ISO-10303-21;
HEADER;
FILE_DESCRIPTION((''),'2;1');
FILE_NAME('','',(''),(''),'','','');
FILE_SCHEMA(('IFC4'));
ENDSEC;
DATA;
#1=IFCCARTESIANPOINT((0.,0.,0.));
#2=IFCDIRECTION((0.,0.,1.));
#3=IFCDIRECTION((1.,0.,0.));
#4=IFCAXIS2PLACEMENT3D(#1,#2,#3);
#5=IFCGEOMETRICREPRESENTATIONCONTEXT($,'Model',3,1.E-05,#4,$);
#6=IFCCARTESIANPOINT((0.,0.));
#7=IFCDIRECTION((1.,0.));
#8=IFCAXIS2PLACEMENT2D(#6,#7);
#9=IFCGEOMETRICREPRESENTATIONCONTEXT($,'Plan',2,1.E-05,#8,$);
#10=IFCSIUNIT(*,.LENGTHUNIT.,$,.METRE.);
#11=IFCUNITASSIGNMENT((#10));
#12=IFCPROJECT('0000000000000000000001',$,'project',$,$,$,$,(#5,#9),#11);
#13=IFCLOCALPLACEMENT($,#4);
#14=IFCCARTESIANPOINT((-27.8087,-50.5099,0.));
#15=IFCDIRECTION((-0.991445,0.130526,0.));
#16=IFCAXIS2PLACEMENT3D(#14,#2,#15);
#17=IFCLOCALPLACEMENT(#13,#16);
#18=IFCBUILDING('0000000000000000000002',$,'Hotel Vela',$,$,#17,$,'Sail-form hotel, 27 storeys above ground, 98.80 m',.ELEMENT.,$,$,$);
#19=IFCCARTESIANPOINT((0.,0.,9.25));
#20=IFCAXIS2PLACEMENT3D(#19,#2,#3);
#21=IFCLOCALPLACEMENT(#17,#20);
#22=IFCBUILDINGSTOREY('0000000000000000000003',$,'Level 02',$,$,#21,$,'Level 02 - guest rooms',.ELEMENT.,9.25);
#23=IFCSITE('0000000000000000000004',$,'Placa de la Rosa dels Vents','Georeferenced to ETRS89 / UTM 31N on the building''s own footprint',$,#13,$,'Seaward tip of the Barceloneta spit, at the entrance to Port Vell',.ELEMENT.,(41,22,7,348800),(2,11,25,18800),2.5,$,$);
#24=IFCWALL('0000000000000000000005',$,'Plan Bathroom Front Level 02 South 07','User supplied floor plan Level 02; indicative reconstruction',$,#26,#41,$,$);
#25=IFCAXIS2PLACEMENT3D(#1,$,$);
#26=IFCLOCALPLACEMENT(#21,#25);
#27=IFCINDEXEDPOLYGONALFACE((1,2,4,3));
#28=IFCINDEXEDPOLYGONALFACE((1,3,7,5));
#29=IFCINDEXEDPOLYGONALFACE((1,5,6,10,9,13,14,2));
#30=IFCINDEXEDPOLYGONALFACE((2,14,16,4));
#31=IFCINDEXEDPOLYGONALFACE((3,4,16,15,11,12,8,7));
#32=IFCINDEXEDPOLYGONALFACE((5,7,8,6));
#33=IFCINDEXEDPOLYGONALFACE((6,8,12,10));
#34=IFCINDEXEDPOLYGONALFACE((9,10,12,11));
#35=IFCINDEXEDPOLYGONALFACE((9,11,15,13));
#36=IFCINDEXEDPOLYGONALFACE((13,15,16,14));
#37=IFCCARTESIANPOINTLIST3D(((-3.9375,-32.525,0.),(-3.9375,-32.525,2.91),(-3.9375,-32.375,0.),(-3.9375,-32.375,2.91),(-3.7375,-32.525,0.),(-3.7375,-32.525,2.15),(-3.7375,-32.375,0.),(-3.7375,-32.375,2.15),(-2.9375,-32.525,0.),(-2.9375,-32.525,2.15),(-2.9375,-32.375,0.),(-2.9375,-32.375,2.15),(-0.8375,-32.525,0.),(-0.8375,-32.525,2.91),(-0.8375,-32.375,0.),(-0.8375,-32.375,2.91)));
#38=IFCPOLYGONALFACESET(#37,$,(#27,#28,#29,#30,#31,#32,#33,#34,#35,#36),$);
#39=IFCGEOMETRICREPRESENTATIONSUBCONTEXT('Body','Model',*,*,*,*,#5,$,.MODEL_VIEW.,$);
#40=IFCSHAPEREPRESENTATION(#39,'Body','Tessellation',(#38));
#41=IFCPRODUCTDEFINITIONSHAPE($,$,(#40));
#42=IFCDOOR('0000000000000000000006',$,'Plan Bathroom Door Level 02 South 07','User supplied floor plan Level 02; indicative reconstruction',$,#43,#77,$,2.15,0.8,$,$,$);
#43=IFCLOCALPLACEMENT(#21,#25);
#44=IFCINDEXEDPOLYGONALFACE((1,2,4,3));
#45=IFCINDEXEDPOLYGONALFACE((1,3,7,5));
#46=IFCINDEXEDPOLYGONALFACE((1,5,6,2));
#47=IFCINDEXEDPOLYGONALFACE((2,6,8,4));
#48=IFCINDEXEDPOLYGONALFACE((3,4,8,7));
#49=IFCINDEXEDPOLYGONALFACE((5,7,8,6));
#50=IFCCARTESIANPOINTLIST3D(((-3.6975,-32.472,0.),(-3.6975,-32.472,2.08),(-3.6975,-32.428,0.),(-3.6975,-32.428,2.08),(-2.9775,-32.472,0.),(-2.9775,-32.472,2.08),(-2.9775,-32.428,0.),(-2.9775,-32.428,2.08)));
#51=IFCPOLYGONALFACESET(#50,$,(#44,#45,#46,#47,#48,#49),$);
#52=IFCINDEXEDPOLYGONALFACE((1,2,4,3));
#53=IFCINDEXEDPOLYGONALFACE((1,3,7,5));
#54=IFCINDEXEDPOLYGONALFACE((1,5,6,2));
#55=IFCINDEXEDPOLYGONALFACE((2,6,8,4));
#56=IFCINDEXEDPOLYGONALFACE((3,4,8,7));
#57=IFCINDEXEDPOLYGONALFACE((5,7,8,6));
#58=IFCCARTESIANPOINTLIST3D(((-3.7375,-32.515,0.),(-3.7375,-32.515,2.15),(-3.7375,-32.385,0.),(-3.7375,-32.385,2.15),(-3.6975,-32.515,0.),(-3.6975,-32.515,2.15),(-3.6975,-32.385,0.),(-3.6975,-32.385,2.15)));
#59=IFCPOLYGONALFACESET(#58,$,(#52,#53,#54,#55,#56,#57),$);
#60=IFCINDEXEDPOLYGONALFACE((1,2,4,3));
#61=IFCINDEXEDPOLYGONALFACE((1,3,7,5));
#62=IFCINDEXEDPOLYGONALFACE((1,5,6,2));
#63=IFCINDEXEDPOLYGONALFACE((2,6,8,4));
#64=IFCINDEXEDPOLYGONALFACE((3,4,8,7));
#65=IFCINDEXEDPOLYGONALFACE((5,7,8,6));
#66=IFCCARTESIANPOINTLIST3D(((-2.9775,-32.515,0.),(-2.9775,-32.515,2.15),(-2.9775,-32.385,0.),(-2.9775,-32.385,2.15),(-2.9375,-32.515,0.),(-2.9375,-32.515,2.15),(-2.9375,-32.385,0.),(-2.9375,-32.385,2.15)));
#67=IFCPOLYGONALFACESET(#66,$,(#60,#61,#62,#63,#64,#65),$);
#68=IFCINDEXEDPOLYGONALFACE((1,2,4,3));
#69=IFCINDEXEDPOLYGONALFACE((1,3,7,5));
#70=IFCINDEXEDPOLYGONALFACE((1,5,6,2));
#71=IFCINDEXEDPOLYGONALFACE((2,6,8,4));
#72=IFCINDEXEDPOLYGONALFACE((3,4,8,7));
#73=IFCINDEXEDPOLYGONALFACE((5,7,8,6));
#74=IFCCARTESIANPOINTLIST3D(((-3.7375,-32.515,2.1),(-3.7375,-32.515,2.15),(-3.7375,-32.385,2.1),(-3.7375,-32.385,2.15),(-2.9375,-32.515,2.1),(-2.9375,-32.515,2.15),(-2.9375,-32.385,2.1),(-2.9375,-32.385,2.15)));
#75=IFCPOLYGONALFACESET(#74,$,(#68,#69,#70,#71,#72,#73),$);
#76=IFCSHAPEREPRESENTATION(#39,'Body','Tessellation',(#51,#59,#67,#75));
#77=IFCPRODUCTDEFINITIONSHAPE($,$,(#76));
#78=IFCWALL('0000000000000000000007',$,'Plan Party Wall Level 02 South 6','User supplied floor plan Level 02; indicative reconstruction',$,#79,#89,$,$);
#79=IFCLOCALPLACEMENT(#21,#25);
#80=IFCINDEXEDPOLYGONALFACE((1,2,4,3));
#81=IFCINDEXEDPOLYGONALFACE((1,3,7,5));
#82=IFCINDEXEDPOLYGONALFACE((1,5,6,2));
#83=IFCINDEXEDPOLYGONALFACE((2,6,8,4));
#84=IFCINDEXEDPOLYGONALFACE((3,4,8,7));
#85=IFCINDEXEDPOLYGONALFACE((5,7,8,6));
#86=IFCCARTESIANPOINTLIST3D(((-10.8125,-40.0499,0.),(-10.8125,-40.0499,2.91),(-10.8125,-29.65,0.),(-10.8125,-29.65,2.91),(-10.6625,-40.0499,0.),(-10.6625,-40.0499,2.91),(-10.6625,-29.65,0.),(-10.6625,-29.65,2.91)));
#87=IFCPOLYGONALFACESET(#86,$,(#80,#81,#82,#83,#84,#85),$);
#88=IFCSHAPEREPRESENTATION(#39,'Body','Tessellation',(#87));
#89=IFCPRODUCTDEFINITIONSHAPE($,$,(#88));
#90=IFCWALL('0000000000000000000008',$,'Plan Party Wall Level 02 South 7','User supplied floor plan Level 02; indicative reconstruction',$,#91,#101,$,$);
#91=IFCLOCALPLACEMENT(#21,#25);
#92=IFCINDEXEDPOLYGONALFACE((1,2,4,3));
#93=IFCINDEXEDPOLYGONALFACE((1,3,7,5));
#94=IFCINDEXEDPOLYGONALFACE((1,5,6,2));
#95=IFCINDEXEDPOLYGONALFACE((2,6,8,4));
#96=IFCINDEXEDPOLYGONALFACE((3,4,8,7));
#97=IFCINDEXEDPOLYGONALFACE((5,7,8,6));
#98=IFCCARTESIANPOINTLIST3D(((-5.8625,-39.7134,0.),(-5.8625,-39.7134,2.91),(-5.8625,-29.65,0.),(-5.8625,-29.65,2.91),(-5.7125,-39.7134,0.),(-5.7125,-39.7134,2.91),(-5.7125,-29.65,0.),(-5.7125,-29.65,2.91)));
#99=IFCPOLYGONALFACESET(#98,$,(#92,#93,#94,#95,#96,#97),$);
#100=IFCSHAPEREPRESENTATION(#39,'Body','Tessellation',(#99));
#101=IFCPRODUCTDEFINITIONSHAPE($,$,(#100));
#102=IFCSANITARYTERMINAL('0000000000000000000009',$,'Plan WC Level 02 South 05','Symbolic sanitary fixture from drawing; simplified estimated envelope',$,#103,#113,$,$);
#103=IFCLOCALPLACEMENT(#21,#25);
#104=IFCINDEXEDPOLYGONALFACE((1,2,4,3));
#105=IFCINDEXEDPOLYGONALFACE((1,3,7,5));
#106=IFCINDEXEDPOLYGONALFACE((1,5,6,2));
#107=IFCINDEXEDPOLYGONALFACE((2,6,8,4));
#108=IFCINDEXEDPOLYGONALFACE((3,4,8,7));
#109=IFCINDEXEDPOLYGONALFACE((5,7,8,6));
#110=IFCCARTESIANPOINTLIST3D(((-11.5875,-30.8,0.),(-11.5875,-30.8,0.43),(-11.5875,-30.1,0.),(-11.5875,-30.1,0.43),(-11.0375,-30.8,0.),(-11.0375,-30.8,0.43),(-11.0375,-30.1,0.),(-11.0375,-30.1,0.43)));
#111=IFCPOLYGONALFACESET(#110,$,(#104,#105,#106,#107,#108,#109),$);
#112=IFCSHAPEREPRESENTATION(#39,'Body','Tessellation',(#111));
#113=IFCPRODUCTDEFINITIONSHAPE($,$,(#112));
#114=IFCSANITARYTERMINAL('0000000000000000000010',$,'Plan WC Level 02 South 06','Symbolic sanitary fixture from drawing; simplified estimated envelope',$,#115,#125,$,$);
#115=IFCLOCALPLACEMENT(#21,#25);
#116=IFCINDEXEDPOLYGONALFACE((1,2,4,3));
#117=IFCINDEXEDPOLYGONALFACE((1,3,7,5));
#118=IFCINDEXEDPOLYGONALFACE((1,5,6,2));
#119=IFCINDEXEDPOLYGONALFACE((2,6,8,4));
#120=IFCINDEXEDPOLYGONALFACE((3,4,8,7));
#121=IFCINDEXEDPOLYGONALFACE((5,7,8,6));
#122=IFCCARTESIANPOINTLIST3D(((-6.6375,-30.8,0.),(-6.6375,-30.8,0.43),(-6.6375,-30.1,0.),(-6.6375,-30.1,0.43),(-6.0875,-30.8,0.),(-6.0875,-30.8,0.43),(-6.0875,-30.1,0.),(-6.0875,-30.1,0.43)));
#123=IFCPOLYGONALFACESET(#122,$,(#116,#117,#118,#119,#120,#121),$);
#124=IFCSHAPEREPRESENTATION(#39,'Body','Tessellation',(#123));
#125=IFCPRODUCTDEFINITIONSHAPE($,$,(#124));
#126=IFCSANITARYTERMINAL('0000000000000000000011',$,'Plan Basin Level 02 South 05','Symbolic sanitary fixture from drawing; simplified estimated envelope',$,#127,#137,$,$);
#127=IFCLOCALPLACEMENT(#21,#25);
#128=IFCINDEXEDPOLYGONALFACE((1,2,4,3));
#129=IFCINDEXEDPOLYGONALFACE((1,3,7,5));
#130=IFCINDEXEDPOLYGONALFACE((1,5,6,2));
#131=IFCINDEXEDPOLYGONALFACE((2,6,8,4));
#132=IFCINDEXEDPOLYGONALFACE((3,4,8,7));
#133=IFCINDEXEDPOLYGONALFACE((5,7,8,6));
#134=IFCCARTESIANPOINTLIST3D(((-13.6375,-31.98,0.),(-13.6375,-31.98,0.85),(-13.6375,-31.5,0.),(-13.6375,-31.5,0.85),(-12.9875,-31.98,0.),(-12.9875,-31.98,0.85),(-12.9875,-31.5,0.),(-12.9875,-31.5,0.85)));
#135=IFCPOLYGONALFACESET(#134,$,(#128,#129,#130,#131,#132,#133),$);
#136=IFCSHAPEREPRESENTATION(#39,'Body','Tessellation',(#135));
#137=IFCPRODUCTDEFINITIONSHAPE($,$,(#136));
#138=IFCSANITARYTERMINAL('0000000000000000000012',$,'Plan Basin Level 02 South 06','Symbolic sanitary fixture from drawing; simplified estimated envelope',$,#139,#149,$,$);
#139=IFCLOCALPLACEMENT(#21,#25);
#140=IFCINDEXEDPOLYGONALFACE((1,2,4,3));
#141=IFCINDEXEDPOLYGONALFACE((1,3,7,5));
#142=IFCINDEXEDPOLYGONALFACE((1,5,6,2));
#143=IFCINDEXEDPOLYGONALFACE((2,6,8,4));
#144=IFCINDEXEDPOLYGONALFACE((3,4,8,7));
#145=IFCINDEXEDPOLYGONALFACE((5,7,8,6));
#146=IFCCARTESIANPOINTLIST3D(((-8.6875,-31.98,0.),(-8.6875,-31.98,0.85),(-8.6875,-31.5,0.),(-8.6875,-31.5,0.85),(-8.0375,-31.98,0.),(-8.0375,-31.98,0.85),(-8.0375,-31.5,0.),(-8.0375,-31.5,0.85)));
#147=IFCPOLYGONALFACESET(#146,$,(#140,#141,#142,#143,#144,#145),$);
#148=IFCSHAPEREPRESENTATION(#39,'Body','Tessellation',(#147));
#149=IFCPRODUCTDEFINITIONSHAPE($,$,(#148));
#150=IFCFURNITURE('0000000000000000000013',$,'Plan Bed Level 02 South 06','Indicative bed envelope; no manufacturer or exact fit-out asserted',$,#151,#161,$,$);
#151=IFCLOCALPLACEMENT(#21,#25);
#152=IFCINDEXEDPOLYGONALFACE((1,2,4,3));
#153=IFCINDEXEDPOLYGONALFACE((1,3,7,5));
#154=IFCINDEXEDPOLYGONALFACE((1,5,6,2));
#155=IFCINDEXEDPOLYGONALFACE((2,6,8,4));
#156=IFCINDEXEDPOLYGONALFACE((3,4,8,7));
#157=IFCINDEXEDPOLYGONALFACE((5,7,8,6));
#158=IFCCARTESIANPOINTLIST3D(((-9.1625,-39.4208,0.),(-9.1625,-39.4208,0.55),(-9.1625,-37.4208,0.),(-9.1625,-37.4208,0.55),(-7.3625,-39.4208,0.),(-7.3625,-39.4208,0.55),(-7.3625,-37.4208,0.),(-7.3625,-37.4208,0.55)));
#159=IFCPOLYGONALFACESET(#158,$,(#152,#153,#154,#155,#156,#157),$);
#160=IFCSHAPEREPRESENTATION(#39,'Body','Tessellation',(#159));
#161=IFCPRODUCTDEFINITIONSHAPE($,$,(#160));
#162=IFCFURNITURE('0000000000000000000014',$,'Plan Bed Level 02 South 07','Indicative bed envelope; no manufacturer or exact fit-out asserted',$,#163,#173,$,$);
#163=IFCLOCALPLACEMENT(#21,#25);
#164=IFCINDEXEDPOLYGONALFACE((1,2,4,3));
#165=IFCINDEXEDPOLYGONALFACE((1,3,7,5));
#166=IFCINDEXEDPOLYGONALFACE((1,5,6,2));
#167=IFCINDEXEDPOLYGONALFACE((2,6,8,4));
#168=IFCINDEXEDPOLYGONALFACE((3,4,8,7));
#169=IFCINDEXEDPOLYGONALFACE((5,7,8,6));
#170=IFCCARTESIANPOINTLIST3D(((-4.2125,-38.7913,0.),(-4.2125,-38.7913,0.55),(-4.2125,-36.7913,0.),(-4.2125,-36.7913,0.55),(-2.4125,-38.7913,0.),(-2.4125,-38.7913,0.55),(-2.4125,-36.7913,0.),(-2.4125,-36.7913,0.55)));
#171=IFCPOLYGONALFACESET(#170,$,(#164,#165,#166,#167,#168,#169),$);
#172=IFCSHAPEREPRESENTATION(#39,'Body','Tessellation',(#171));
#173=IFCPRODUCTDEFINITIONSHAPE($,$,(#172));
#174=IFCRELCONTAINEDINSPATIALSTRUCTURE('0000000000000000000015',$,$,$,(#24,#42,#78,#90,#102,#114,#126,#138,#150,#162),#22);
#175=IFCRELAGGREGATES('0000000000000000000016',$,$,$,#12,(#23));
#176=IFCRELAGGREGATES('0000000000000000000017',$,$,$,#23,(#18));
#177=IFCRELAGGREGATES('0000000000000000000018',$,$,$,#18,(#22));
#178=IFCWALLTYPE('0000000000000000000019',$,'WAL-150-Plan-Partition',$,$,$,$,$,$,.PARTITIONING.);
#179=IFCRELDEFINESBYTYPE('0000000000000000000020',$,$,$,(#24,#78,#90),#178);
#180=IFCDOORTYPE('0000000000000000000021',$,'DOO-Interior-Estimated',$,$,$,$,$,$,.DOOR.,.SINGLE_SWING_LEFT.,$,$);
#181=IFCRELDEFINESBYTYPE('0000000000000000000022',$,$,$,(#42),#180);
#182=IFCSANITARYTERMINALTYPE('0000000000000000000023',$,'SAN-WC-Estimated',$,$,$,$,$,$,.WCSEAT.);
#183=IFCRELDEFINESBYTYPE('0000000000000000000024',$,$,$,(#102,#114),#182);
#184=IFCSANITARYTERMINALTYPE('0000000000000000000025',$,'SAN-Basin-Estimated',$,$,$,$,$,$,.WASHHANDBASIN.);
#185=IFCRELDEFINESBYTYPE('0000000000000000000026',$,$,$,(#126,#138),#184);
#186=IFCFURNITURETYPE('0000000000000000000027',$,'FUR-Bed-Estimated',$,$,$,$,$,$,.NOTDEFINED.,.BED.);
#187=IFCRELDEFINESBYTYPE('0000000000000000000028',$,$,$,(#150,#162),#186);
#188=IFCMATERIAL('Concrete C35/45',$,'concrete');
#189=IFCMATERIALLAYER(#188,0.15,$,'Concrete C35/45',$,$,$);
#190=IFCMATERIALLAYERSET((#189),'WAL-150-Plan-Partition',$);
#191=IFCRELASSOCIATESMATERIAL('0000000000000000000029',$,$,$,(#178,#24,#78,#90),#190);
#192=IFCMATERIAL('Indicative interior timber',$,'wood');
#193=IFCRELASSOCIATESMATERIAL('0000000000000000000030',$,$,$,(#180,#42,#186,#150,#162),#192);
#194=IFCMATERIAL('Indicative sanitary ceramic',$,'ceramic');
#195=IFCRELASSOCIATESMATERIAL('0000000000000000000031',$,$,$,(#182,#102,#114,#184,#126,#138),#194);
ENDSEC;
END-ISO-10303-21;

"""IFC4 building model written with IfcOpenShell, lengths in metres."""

from ifc_helpers import new_model, si_unit, frame, origin_with_axes, origin_2d_with_axis, place, context, subcontext, project, spatial, line, indexed_curve, outline, extrude, material, layer, layer_set, layer_usage, type_object, element, fill, save


model = new_model("IFC4")

# Units and contexts
model_context = context("Model", 3, precision=1e-05, world=origin_with_axes())
plan_context = context("Plan", 2, precision=1e-05, world=origin_2d_with_axis())
body_context = subcontext(model_context, "Body", "Model", "MODEL_VIEW")
ifc_project = project(units=[si_unit("LENGTHUNIT", "METRE")], contexts=[model_context, plan_context])

# Site, building, storey
site_placement = place(None, origin_with_axes())
site = spatial("IfcSite", under=ifc_project, at=site_placement, Name="Placa de la Rosa dels Vents", Description="Georeferenced to ETRS89 / UTM 31N on the building's own footprint", LongName="Seaward tip of the Barceloneta spit, at the entrance to Port Vell", CompositionType="ELEMENT", RefLatitude=(41, 22, 7, 348800), RefLongitude=(2, 11, 25, 18800), RefElevation=2.5)
building_placement = place(site_placement, frame((-27.8087, -50.5099, 0.0), z_axis=(0.0, 0.0, 1.0), x_axis=(-0.991445, 0.130526, 0.0)))
building = spatial("IfcBuilding", under=site, at=building_placement, Name="Hotel Vela", LongName="Sail-form hotel, 27 storeys above ground, 98.80 m", CompositionType="ELEMENT")
storey_placement = place(building_placement, frame((0.0, 0.0, 9.25), z_axis=(0.0, 0.0, 1.0), x_axis=(1.0, 0.0, 0.0)))
storey = spatial("IfcBuildingStorey", under=building, at=storey_placement, Name="Level 02", LongName="Level 02 - guest rooms", CompositionType="ELEMENT", Elevation=9.25)

# Shared definitions
ifc_material_1 = material(Name="Concrete C35/45", Category="concrete")
ifc_layer = layer(ifc_material_1, 0.15, Name="Concrete C35/45")
ifc_layer_set = layer_set([ifc_layer], Name="WAL-150-Plan-Partition")
wall_type = type_object("IfcWallType", Name="WAL-150-Plan-Partition", PredefinedType="PARTITIONING", material=ifc_layer_set)

# Shared definitions
ifc_material_2 = material(Name="Indicative interior timber", Category="wood")
door_type = type_object("IfcDoorType", Name="DOO-Interior-Estimated", OperationType="SINGLE_SWING_LEFT", PredefinedType="DOOR", material=ifc_material_2)

# Wall, opening, door
ifc_layer_usage_1 = layer_usage(ifc_layer_set, "AXIS2", "POSITIVE", 0.0)
wall_1_placement = place(storey_placement, frame((-3.9375, -32.525, 0.0), z_axis=(0.0, 0.0, 1.0), x_axis=(1.0, 0.0, 0.0)))
wall_1 = element("IfcWall", 1, at=wall_1_placement, inside=storey, type_object=wall_type, material=ifc_layer_usage_1, Name="Plan Bathroom Front Level 02 South 07", Description="User supplied floor plan Level 02; indicative reconstruction", context=body_context, shape_type="SweptSolid", body=[
    extrude(outline(indexed_curve([(0.0, 0.0), (3.1, 0.0), (3.1, 0.15), (0.0, 0.15)], segments=[line(1, 2, 3, 4, 1)])), origin_with_axes(), (0.0, 0.0, 1.0), 2.91),
])
opening_1_placement = place(wall_1_placement, frame((0.2, -0.085, 0.0), z_axis=(0.0, 0.0, 1.0), x_axis=(1.0, 0.0, 0.0)))
opening_1 = element("IfcOpeningElement", 2, at=opening_1_placement, cuts=wall_1, PredefinedType="OPENING", context=body_context, shape_type="SweptSolid", body=[
    extrude(outline(indexed_curve([(0.0, 0.0), (0.8, 0.0), (0.8, 0.32), (0.0, 0.32)], segments=[line(1, 2, 3, 4, 1)])), origin_with_axes(), (0.0, 0.0, 1.0), 2.15),
])
door_1_placement = place(storey_placement, frame((0.0, 0.0, -9.25), z_axis=(0.0, 0.0, 1.0), x_axis=(1.0, 0.0, 0.0)))
door_1 = element("IfcDoor", 3, at=door_1_placement, inside=storey, type_object=door_type, material=ifc_material_2, Name="Plan Bathroom Door Level 02 South 07", Description="User supplied floor plan Level 02; indicative reconstruction", OverallHeight=2.15, OverallWidth=0.8, context=body_context, shape_type="SweptSolid", body=[
    extrude(outline(indexed_curve([(0.0, 0.0), (0.72, 0.0), (0.72, 0.044), (0.0, 0.044)], segments=[line(1, 2, 3, 4, 1)])), frame((-3.6975, -32.472, 9.25), z_axis=(0.0, 0.0, 1.0), x_axis=(1.0, 0.0, 0.0)), (0.0, 0.0, 1.0), 2.08),
    extrude(outline(indexed_curve([(0.0, 0.0), (0.04, 0.0), (0.04, 0.13), (0.0, 0.13)], segments=[line(1, 2, 3, 4, 1)])), frame((-3.7375, -32.515, 9.25), z_axis=(0.0, 0.0, 1.0), x_axis=(1.0, 0.0, 0.0)), (0.0, 0.0, 1.0), 2.15),
    extrude(outline(indexed_curve([(0.0, 0.0), (0.04, 0.0), (0.04, 0.13), (0.0, 0.13)], segments=[line(1, 2, 3, 4, 1)])), frame((-2.9775, -32.515, 9.25), z_axis=(0.0, 0.0, 1.0), x_axis=(1.0, 0.0, 0.0)), (0.0, 0.0, 1.0), 2.15),
    extrude(outline(indexed_curve([(0.0, 0.0), (0.8, 0.0), (0.8, 0.13), (0.0, 0.13)], segments=[line(1, 2, 3, 4, 1)])), frame((-3.7375, -32.515, 11.35), z_axis=(0.0, 0.0, 1.0), x_axis=(1.0, 0.0, 0.0)), (0.0, 0.0, 1.0), 0.05),
])
fill(opening_1, door_1)

# Walls
ifc_layer_usage_2 = layer_usage(ifc_layer_set, "AXIS2", "POSITIVE", 0.0)
wall_2_placement = place(storey_placement, frame((-10.8125, -40.0499, 0.0), z_axis=(0.0, 0.0, 1.0), x_axis=(1.0, 0.0, 0.0)))
element("IfcWall", 4, at=wall_2_placement, inside=storey, type_object=wall_type, material=ifc_layer_usage_2, Name="Plan Party Wall Level 02 South 6", Description="User supplied floor plan Level 02; indicative reconstruction", context=body_context, shape_type="SweptSolid", body=[
    extrude(outline(indexed_curve([(0.0, 0.0), (0.15, 0.0), (0.15, 10.3999), (0.0, 10.3999)], segments=[line(1, 2, 3, 4, 1)])), origin_with_axes(), (0.0, 0.0, 1.0), 2.91),
])
ifc_layer_usage_3 = layer_usage(ifc_layer_set, "AXIS2", "POSITIVE", 0.0)
wall_3_placement = place(storey_placement, frame((-5.8625, -39.7134, 0.0), z_axis=(0.0, 0.0, 1.0), x_axis=(1.0, 0.0, 0.0)))
element("IfcWall", 5, at=wall_3_placement, inside=storey, type_object=wall_type, material=ifc_layer_usage_3, Name="Plan Party Wall Level 02 South 7", Description="User supplied floor plan Level 02; indicative reconstruction", context=body_context, shape_type="SweptSolid", body=[
    extrude(outline(indexed_curve([(0.0, 0.0), (0.15, 0.0), (0.15, 10.0634), (0.0, 10.0634)], segments=[line(1, 2, 3, 4, 1)])), origin_with_axes(), (0.0, 0.0, 1.0), 2.91),
])

# Sanitary terminals
ifc_material_3 = material(Name="Indicative sanitary ceramic", Category="ceramic")
sanitary_terminal_type_1 = type_object("IfcSanitaryTerminalType", Name="SAN-WC-Estimated", PredefinedType="WCSEAT", material=ifc_material_3)
for number, where, z_axis, x_axis, name in (
    (6, (-11.5875, -30.8, 0.0), (0.0, 0.0, 1.0), (1.0, 0.0, 0.0), "Plan WC Level 02 South 05"),
    (7, (-6.6375, -30.8, 0.0), (0.0, 0.0, 1.0), (1.0, 0.0, 0.0), "Plan WC Level 02 South 06"),
):
    element("IfcSanitaryTerminal", number, at=place(storey_placement, frame(where, z_axis=z_axis, x_axis=x_axis)), inside=storey, type_object=sanitary_terminal_type_1, material=ifc_material_3, Name=name, Description="Symbolic sanitary fixture from drawing; simplified estimated envelope", context=body_context, shape_type="SweptSolid", body=[
        extrude(outline(indexed_curve([(0.0, 0.0), (0.55, 0.0), (0.55, 0.7), (0.0, 0.7)], segments=[line(1, 2, 3, 4, 1)])), origin_with_axes(), (0.0, 0.0, 1.0), 0.43),
    ])
sanitary_terminal_type_2 = type_object("IfcSanitaryTerminalType", Name="SAN-Basin-Estimated", PredefinedType="WASHHANDBASIN", material=ifc_material_3)
for number, where, z_axis, x_axis, name in (
    (8, (-13.6375, -31.98, 0.0), (0.0, 0.0, 1.0), (1.0, 0.0, 0.0), "Plan Basin Level 02 South 05"),
    (9, (-8.6875, -31.98, 0.0), (0.0, 0.0, 1.0), (1.0, 0.0, 0.0), "Plan Basin Level 02 South 06"),
):
    element("IfcSanitaryTerminal", number, at=place(storey_placement, frame(where, z_axis=z_axis, x_axis=x_axis)), inside=storey, type_object=sanitary_terminal_type_2, material=ifc_material_3, Name=name, Description="Symbolic sanitary fixture from drawing; simplified estimated envelope", context=body_context, shape_type="SweptSolid", body=[
        extrude(outline(indexed_curve([(0.0, 0.0), (0.65, 0.0), (0.65, 0.48), (0.0, 0.48)], segments=[line(1, 2, 3, 4, 1)])), origin_with_axes(), (0.0, 0.0, 1.0), 0.85),
    ])

# Furniture
furniture_type = type_object("IfcFurnitureType", Name="FUR-Bed-Estimated", AssemblyPlace="NOTDEFINED", PredefinedType="BED", material=ifc_material_2)
for number, where, z_axis, x_axis, name in (
    (10, (-9.1625, -39.4208, 0.0), (0.0, 0.0, 1.0), (1.0, 0.0, 0.0), "Plan Bed Level 02 South 06"),
    (11, (-4.2125, -38.7913, 0.0), (0.0, 0.0, 1.0), (1.0, 0.0, 0.0), "Plan Bed Level 02 South 07"),
):
    element("IfcFurniture", number, at=place(storey_placement, frame(where, z_axis=z_axis, x_axis=x_axis)), inside=storey, type_object=furniture_type, material=ifc_material_2, Name=name, Description="Indicative bed envelope; no manufacturer or exact fit-out asserted", context=body_context, shape_type="SweptSolid", body=[
        extrude(outline(indexed_curve([(0.0, 0.0), (1.8, 0.0), (1.8, 2.0), (0.0, 2.0)], segments=[line(1, 2, 3, 4, 1)])), origin_with_axes(), (0.0, 0.0, 1.0), 0.55),
    ])

save(model, "model.ifc")
